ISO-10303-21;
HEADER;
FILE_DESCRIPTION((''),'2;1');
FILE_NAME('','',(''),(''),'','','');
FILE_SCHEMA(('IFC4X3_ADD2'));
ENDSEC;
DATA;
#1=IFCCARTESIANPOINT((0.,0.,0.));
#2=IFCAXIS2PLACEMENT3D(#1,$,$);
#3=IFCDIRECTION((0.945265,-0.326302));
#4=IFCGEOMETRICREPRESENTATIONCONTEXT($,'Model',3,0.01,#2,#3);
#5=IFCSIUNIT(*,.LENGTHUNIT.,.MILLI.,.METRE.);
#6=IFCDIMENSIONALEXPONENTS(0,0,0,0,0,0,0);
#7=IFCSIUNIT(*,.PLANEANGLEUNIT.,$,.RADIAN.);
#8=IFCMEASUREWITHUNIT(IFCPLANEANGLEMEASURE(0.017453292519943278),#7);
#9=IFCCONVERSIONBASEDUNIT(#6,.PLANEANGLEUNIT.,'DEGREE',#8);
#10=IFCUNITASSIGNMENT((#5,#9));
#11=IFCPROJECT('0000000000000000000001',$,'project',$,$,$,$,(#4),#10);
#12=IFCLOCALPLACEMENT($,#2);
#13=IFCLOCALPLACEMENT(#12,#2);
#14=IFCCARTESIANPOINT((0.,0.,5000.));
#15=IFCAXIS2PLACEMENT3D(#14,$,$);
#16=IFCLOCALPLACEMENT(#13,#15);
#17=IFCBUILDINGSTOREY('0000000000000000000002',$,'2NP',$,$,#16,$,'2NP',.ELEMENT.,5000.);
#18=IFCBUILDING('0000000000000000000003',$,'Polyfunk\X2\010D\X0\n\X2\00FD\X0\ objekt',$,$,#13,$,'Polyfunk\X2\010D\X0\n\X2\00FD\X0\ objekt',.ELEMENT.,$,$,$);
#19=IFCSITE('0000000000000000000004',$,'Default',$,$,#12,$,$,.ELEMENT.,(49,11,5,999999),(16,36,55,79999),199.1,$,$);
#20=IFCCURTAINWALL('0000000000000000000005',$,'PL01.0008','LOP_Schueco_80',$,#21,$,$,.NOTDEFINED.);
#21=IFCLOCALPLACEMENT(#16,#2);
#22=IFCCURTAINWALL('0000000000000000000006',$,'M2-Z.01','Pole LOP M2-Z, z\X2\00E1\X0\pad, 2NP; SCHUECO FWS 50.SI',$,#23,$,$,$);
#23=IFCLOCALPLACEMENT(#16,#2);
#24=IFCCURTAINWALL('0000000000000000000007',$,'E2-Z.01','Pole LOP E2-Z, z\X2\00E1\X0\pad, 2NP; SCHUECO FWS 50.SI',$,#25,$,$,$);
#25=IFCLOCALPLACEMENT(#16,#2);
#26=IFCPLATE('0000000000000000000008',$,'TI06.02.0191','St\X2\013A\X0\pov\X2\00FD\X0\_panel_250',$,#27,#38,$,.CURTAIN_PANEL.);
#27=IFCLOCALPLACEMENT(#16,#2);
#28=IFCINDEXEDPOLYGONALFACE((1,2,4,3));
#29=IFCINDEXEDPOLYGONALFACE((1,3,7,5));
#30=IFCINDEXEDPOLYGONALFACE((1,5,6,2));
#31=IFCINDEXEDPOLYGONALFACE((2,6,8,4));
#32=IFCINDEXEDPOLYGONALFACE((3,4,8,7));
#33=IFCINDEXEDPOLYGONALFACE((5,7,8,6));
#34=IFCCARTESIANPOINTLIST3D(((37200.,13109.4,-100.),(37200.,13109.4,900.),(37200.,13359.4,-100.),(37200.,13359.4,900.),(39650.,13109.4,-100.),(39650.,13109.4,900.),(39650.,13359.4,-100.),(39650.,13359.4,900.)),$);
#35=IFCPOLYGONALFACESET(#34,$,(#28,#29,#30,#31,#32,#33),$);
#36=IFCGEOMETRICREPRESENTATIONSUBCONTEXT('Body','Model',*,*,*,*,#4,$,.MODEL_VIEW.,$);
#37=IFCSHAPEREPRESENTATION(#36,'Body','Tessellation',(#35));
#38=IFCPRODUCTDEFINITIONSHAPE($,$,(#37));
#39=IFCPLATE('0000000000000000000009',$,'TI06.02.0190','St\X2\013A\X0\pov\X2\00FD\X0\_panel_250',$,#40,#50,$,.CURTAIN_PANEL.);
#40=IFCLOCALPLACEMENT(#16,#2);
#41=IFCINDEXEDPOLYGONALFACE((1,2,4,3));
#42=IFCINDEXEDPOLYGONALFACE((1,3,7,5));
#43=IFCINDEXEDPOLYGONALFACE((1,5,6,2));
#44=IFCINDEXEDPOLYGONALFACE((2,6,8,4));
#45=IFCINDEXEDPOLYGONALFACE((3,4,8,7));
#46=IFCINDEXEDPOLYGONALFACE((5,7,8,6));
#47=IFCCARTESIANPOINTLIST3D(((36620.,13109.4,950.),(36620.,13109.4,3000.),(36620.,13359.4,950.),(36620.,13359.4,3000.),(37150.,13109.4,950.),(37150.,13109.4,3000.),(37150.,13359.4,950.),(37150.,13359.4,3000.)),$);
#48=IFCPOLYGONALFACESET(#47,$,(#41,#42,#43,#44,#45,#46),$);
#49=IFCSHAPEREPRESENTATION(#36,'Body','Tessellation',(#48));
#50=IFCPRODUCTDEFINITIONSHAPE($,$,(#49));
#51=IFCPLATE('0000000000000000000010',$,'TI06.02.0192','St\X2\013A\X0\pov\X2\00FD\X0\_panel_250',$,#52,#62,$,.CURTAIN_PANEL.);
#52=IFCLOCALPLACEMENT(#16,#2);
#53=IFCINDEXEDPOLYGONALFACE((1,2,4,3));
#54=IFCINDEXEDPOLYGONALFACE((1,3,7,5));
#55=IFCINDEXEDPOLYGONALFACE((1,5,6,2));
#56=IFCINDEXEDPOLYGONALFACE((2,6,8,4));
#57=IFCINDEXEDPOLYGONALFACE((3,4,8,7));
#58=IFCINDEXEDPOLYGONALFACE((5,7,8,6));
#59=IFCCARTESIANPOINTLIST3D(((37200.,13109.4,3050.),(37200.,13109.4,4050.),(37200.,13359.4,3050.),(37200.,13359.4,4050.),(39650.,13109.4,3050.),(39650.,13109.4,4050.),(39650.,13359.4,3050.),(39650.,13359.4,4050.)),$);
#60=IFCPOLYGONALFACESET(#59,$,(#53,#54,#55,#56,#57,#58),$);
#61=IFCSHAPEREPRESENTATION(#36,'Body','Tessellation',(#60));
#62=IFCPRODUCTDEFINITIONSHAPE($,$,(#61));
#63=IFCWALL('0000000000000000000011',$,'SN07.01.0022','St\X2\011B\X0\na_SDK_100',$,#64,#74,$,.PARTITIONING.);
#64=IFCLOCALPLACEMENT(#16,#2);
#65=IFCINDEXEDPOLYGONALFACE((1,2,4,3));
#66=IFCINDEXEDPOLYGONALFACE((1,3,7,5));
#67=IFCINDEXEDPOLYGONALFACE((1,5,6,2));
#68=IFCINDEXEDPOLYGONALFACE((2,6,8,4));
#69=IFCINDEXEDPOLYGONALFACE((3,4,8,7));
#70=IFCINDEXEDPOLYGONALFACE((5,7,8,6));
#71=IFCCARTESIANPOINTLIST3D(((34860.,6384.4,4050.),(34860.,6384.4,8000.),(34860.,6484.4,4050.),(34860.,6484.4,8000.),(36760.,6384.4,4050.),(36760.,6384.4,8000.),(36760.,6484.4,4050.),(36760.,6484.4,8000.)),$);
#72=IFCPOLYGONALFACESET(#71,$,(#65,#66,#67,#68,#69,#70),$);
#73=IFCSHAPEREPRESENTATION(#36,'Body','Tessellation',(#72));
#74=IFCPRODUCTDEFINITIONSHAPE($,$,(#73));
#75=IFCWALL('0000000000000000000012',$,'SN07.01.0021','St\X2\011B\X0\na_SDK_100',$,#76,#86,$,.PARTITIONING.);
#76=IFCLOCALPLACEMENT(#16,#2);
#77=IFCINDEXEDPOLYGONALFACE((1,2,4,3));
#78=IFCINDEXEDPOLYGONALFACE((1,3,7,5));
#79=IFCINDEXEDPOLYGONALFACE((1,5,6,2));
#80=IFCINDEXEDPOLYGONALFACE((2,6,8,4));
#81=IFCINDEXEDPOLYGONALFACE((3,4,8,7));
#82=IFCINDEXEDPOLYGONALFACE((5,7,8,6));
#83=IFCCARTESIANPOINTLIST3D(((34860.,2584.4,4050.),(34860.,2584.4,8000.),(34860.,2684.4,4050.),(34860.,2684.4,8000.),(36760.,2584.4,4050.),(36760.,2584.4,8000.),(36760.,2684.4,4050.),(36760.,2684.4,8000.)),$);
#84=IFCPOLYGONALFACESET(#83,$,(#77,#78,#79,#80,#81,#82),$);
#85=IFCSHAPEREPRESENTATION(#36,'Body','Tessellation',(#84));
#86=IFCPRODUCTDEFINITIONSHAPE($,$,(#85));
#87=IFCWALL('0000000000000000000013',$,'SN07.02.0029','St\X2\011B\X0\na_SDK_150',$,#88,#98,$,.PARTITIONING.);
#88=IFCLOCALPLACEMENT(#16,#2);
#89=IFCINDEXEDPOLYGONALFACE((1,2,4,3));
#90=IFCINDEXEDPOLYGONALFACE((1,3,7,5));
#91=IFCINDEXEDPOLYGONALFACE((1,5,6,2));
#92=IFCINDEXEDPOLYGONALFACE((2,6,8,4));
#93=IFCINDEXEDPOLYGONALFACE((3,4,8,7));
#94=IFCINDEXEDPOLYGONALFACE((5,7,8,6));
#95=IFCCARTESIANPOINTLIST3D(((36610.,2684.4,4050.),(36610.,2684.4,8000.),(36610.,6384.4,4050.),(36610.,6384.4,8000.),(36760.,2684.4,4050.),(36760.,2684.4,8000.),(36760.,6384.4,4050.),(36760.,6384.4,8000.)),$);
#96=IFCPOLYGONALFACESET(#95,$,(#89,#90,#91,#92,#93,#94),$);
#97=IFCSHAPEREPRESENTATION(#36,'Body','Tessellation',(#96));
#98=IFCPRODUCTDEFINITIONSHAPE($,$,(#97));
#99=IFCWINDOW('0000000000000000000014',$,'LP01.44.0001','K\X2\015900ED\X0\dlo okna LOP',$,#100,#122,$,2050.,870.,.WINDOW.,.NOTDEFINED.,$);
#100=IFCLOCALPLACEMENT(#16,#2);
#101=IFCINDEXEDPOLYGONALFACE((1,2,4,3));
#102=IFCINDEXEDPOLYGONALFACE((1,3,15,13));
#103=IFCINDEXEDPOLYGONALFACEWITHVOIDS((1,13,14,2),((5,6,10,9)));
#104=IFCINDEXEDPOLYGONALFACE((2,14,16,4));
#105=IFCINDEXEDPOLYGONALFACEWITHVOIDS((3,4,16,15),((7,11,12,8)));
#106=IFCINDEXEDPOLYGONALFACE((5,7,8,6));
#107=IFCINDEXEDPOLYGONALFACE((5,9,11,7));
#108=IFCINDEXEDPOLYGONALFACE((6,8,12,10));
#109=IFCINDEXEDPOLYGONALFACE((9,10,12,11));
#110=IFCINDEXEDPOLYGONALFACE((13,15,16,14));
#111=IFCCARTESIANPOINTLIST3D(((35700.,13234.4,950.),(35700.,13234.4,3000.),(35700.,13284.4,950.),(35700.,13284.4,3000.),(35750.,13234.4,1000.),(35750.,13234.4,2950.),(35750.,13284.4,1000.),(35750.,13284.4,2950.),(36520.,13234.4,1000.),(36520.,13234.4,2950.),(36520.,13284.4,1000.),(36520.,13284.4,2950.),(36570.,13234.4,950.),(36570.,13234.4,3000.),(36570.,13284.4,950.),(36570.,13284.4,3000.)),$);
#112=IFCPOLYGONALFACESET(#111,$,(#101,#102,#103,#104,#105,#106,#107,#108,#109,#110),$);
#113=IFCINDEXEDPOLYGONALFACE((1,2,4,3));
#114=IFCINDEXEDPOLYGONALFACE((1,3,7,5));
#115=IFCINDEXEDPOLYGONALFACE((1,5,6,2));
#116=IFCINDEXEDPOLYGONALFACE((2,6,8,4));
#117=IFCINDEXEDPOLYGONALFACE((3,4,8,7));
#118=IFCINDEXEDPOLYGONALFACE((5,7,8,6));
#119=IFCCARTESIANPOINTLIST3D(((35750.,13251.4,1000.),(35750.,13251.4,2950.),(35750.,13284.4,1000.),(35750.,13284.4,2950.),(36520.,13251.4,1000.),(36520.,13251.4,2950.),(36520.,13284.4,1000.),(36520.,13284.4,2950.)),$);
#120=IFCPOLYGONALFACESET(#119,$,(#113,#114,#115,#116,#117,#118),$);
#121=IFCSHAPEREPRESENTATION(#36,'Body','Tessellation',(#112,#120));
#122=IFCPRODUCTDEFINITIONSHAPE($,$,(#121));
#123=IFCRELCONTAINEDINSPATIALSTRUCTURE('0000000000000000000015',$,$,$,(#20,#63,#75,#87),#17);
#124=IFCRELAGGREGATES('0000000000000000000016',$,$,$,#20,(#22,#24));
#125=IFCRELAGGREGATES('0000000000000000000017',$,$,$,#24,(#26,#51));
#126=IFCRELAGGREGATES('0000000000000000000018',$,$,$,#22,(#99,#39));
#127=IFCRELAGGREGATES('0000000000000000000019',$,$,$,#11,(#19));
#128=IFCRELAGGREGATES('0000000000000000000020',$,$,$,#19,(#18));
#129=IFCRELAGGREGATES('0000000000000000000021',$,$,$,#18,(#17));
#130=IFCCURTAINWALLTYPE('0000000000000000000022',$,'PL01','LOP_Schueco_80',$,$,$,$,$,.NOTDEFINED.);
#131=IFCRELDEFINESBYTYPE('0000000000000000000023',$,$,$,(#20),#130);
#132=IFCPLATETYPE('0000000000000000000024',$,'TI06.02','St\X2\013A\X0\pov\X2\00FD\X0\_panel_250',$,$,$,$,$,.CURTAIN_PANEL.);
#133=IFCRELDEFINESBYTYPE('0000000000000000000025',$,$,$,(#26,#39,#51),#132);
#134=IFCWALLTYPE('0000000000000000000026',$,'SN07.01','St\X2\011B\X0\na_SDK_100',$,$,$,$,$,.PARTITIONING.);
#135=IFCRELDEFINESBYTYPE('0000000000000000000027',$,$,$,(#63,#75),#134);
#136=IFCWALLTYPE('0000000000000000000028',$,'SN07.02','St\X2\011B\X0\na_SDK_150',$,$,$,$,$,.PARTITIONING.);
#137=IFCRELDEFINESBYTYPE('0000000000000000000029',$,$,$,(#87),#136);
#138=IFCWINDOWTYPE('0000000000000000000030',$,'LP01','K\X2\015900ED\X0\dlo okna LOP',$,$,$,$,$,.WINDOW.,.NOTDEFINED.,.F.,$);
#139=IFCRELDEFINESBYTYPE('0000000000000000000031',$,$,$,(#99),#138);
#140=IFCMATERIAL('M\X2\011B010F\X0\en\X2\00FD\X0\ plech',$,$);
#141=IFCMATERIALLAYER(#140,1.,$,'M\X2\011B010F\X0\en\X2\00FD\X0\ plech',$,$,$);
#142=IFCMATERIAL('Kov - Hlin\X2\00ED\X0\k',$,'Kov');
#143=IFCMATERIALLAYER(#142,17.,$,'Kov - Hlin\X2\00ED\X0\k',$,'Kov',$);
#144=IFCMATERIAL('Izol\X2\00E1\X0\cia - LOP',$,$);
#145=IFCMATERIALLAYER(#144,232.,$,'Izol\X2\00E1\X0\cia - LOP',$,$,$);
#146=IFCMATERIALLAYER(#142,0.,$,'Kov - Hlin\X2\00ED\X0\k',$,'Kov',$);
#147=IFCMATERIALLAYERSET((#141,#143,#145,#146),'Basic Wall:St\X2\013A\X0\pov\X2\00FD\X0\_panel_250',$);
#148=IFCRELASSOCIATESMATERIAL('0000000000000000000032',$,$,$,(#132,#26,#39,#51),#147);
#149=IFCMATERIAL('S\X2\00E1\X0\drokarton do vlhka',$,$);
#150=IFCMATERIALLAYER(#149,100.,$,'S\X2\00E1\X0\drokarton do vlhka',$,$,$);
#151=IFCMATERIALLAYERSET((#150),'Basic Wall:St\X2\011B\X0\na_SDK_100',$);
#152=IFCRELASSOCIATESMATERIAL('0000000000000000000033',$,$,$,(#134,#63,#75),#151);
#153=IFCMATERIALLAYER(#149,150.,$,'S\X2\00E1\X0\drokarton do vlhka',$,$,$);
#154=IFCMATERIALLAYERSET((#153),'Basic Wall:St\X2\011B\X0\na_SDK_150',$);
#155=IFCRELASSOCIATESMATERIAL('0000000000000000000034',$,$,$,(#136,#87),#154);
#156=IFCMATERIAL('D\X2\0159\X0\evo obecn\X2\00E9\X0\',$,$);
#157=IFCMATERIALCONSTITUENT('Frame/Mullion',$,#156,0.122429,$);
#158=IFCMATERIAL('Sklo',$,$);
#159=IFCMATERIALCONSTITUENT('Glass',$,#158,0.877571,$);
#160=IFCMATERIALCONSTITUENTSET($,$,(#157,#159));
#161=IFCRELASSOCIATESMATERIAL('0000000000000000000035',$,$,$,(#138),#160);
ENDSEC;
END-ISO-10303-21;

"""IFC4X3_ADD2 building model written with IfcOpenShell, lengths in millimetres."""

from ifc_helpers import new_model, entity, si_unit, converted_unit, direction, frame, frame_2d, origin, origin_2d_with_axis, place, context, subcontext, project, spatial, polyline, rectangle, outline, extrude, clip, bounded_halfspace, source, transform, mapped, material, layer, layer_set, layer_usage, constituent, constituent_set, type_object, type_shapes, element, aggregate, save


model = new_model("IFC4X3_ADD2")

# Units and contexts
model_context = context("Model", 3, precision=0.01, world=origin(), true_north=direction((0.945265, -0.326302)))
body_context = subcontext(model_context, "Body", "Model", "MODEL_VIEW")
ifc_project = project(units=[si_unit("LENGTHUNIT", "METRE", prefix="MILLI"), converted_unit("PLANEANGLEUNIT", "DEGREE", entity("IfcPlaneAngleMeasure", 0.017453292519943278), si_unit("PLANEANGLEUNIT", "RADIAN"), dimensions=[0, 0, 0, 0, 0, 0, 0])], contexts=[model_context])

# Site, building, storey
site_placement = place(None, origin())
site = spatial("IfcSite", under=ifc_project, at=site_placement, Name="Default", CompositionType="ELEMENT", RefLatitude=(49, 11, 5, 999999), RefLongitude=(16, 36, 55, 79999), RefElevation=199.1)
building_placement = place(site_placement, origin())
building = spatial("IfcBuilding", under=site, at=building_placement, Name="Polyfunkčný objekt", LongName="Polyfunkčný objekt", CompositionType="ELEMENT")
storey_placement = place(building_placement, frame((0.0, 0.0, 5000.0)))
storey = spatial("IfcBuildingStorey", under=building, at=storey_placement, Name="2NP", LongName="2NP", CompositionType="ELEMENT", Elevation=5000.0)

# Curtain walls, plates
curtain_wall_type = type_object("IfcCurtainWallType", Name="PL01", Description="LOP_Schueco_80", PredefinedType="NOTDEFINED")
curtain_wall_1_placement = place(storey_placement, frame((0.0, 0.0, -5000.0)))
curtain_wall_1 = element("IfcCurtainWall", 1, at=curtain_wall_1_placement, inside=storey, type_object=curtain_wall_type, Name="PL01.0008", Description="LOP_Schueco_80", PredefinedType="NOTDEFINED")
curtain_wall_2 = element("IfcCurtainWall", 2, Name="M2-Z.01", Description="Pole LOP M2-Z, západ, 2NP; SCHUECO FWS 50.SI")
curtain_wall_3 = element("IfcCurtainWall", 3, Name="E2-Z.01", Description="Pole LOP E2-Z, západ, 2NP; SCHUECO FWS 50.SI")
aggregate(curtain_wall_1, [curtain_wall_2, curtain_wall_3])
ifc_material_1 = material(Name="Měďený plech")
ifc_layer_1 = layer(ifc_material_1, 1.0, Name="Měďený plech")
ifc_material_2 = material(Name="Kov - Hliník", Category="Kov")
ifc_layer_2 = layer(ifc_material_2, 17.0, Name="Kov - Hliník", Category="Kov")
ifc_material_3 = material(Name="Izolácia - LOP")
ifc_layer_3 = layer(ifc_material_3, 232.0, Name="Izolácia - LOP")
ifc_layer_4 = layer(ifc_material_2, 0.0, Name="Kov - Hliník", Category="Kov")
ifc_layer_set_1 = layer_set([ifc_layer_1, ifc_layer_2, ifc_layer_3, ifc_layer_4], Name="Basic Wall:Stĺpový_panel_250")
ifc_layer_usage_1 = layer_usage(ifc_layer_set_1, "AXIS2", "NEGATIVE", 125.0)
plate_type = type_object("IfcPlateType", Name="TI06.02", Description="Stĺpový_panel_250", PredefinedType="CURTAIN_PANEL", material=ifc_layer_set_1)
plate_1_placement = place(storey_placement, frame((37200.0, 13234.4, -100.0)))
plate_1 = element("IfcPlate", 4, at=plate_1_placement, type_object=plate_type, material=ifc_layer_usage_1, Name="TI06.02.0191", Description="Stĺpový_panel_250", PredefinedType="CURTAIN_PANEL", context=body_context, shape_type="SweptSolid", body=[
    extrude(rectangle(XDim=250.0, YDim=2450.0, at=frame_2d((0.0, 0.0), x_axis=(1.0, 0.0))), frame((1225.0, 0.0, 0.0), z_axis=(0.0, 0.0, 1.0), x_axis=(0.0, 1.0, 0.0)), (0.0, 0.0, 1.0), 1000.0),
])
ifc_layer_usage_2 = layer_usage(ifc_layer_set_1, "AXIS2", "NEGATIVE", 125.0)
plate_2_placement = place(storey_placement, frame((36620.0, 13234.4, 950.0)))
plate_2 = element("IfcPlate", 5, at=plate_2_placement, type_object=plate_type, material=ifc_layer_usage_2, Name="TI06.02.0190", Description="Stĺpový_panel_250", PredefinedType="CURTAIN_PANEL", context=body_context, shape_type="SweptSolid", body=[
    extrude(rectangle(XDim=250.0, YDim=530.0, at=frame_2d((0.0, 0.0), x_axis=(1.0, 0.0))), frame((265.0, 0.0, 0.0), z_axis=(0.0, 0.0, 1.0), x_axis=(0.0, 1.0, 0.0)), (0.0, 0.0, 1.0), 2050.0),
])
ifc_layer_usage_3 = layer_usage(ifc_layer_set_1, "AXIS2", "NEGATIVE", 125.0)
plate_3_placement = place(storey_placement, frame((37200.0, 13234.4, 3050.0)))
plate_3 = element("IfcPlate", 6, at=plate_3_placement, type_object=plate_type, material=ifc_layer_usage_3, Name="TI06.02.0192", Description="Stĺpový_panel_250", PredefinedType="CURTAIN_PANEL", context=body_context, shape_type="SweptSolid", body=[
    extrude(rectangle(XDim=250.0, YDim=2450.0, at=frame_2d((0.0, 0.0), x_axis=(1.0, 0.0))), frame((1225.0, 0.0, 0.0), z_axis=(0.0, 0.0, 1.0), x_axis=(0.0, 1.0, 0.0)), (0.0, 0.0, 1.0), 1000.0),
])
aggregate(curtain_wall_3, [plate_1, plate_3])

# Walls
ifc_material_4 = material(Name="Sádrokarton do vlhka")
ifc_layer_5 = layer(ifc_material_4, 100.0, Name="Sádrokarton do vlhka")
ifc_layer_set_2 = layer_set([ifc_layer_5], Name="Basic Wall:Stěna_SDK_100")
wall_type_1 = type_object("IfcWallType", Name="SN07.01", Description="Stěna_SDK_100", PredefinedType="PARTITIONING", material=ifc_layer_set_2)
wall_1_placement = place(storey_placement, frame((36760.0, 6434.4, 4050.0), z_axis=(0.0, 0.0, 1.0), x_axis=(-1.0, 0.0, 0.0)))
element("IfcWall", 7, at=wall_1_placement, inside=storey, type_object=wall_type_1, material=ifc_layer_set_2, Name="SN07.01.0022", Description="Stěna_SDK_100", PredefinedType="PARTITIONING", context=body_context, shape_type="Clipping", body=[
    clip(clip(extrude(rectangle(XDim=1900.0, YDim=100.0, at=frame_2d((950.0, 0.0), x_axis=(-1.0, 0.0))), origin(), (0.0, 0.0, 1.0), 3950.0), bounded_halfspace(frame((1900.0, -50.0, 0.0)), True, frame((1900.0, -50.0, 0.0)), polyline([(0.0, 0.0), (0.0, 100.0), (-1750.0, 100.0), (-1900.0, 100.0), (-1900.0, 0.0), (0.0, 0.0)]))), bounded_halfspace(frame((0.0, -50.0, 3950.0), z_axis=(0.0, 0.0, -1.0), x_axis=(-1.0, 0.0, 0.0)), True, frame((0.0, -50.0, 3950.0)), polyline([(0.0, 0.0), (1900.0, 0.0), (1900.0, 100.0), (150.0, 100.0), (0.0, 100.0), (0.0, 0.0)]))),
])
wall_2_placement = place(storey_placement, frame((34860.0, 2634.4, 4050.0)))
element("IfcWall", 8, at=wall_2_placement, inside=storey, type_object=wall_type_1, material=ifc_layer_set_2, Name="SN07.01.0021", Description="Stěna_SDK_100", PredefinedType="PARTITIONING", context=body_context, shape_type="Clipping", body=[
    clip(clip(extrude(rectangle(XDim=1900.0, YDim=100.0, at=frame_2d((950.0, 0.0), x_axis=(-1.0, 0.0))), origin(), (0.0, 0.0, 1.0), 3950.0), bounded_halfspace(frame((1900.0, -50.0, 0.0), z_axis=(0.0, 0.0, 1.0), x_axis=(-1.0, 0.0, 0.0)), True, frame((1900.0, -50.0, 0.0)), polyline([(0.0, 0.0), (0.0, 100.0), (-150.0, 100.0), (-1900.0, 100.0), (-1900.0, 0.0), (-1800.0, 0.0), (0.0, 0.0)]))), bounded_halfspace(frame((0.0, -50.0, 3950.0), z_axis=(0.0, 0.0, -1.0), x_axis=(1.0, 0.0, 0.0)), True, frame((0.0, -50.0, 3950.0)), polyline([(0.0, 0.0), (100.0, 0.0), (1900.0, 0.0), (1900.0, 100.0), (1750.0, 100.0), (0.0, 100.0), (0.0, 0.0)]))),
])
ifc_layer_6 = layer(ifc_material_4, 150.0, Name="Sádrokarton do vlhka")
ifc_layer_set_3 = layer_set([ifc_layer_6], Name="Basic Wall:Stěna_SDK_150")
wall_type_2 = type_object("IfcWallType", Name="SN07.02", Description="Stěna_SDK_150", PredefinedType="PARTITIONING", material=ifc_layer_set_3)
wall_3_placement = place(storey_placement, frame((36685.0, 6384.4, 4050.0), z_axis=(0.0, 0.0, 1.0), x_axis=(0.0, -1.0, 0.0)))
element("IfcWall", 9, at=wall_3_placement, inside=storey, type_object=wall_type_2, material=ifc_layer_set_3, Name="SN07.02.0029", Description="Stěna_SDK_150", PredefinedType="PARTITIONING", context=body_context, shape_type="SweptSolid", body=[
    extrude(rectangle(XDim=3700.0, YDim=150.0, at=frame_2d((1850.0, 0.0), x_axis=(-1.0, 0.0))), origin(), (0.0, 0.0, 1.0), 3950.0),
])

# Window
ifc_material_5 = material(Name="Dřevo obecné")
ifc_constituent_1 = constituent(ifc_material_5, Name="Frame/Mullion", fraction=0.122429)
ifc_material_6 = material(Name="Sklo")
ifc_constituent_2 = constituent(ifc_material_6, Name="Glass", fraction=0.877571)
ifc_constituent_set = constituent_set(constituents=[ifc_constituent_1, ifc_constituent_2])
window_type = type_object("IfcWindowType", Name="LP01", Description="Křídlo okna LOP", ParameterTakesPrecedence=False, PartitioningType="NOTDEFINED", PredefinedType="WINDOW", material=ifc_constituent_set)
shared_shape_1 = source(origin(), body_context, "Body", "SweptSolid", [
    extrude(outline(polyline([(-1025.0, -435.0), (1025.0, -435.0), (1025.0, 435.0), (-1025.0, 435.0), (-1025.0, -435.0)]), holes=[polyline([(-975.0, -385.0), (-975.0, 385.0), (975.0, 385.0), (975.0, -385.0), (-975.0, -385.0)])]), frame((0.0, 0.0, 1025.0), z_axis=(0.0, 1.0, 0.0), x_axis=(0.0, 0.0, -1.0)), (0.0, 0.0, 1.0), 50.0),
    extrude(rectangle(XDim=33.0, YDim=770.0, at=origin_2d_with_axis()), frame((0.0, 33.5, 50.0), z_axis=(0.0, 0.0, 1.0), x_axis=(0.0, -1.0, 0.0)), (0.0, 0.0, 1.0), 1950.0),
])
type_shapes(window_type, [shared_shape_1])
window_placement = place(curtain_wall_1_placement, frame((36135.0, 13234.4, 5950.0)))
window = element("IfcWindow", 10, at=window_placement, type_object=window_type, Name="LP01.44.0001", Description="Křídlo okna LOP", OverallHeight=2050.0, OverallWidth=870.0, PartitioningType="NOTDEFINED", PredefinedType="WINDOW", context=body_context, shape_type="MappedRepresentation", body=[
    mapped(shared_shape_1, transform((0.0, 0.0, 0.0), scale=1.0)),
])
aggregate(curtain_wall_2, [window, plate_2])

save(model, "model.ifc")
